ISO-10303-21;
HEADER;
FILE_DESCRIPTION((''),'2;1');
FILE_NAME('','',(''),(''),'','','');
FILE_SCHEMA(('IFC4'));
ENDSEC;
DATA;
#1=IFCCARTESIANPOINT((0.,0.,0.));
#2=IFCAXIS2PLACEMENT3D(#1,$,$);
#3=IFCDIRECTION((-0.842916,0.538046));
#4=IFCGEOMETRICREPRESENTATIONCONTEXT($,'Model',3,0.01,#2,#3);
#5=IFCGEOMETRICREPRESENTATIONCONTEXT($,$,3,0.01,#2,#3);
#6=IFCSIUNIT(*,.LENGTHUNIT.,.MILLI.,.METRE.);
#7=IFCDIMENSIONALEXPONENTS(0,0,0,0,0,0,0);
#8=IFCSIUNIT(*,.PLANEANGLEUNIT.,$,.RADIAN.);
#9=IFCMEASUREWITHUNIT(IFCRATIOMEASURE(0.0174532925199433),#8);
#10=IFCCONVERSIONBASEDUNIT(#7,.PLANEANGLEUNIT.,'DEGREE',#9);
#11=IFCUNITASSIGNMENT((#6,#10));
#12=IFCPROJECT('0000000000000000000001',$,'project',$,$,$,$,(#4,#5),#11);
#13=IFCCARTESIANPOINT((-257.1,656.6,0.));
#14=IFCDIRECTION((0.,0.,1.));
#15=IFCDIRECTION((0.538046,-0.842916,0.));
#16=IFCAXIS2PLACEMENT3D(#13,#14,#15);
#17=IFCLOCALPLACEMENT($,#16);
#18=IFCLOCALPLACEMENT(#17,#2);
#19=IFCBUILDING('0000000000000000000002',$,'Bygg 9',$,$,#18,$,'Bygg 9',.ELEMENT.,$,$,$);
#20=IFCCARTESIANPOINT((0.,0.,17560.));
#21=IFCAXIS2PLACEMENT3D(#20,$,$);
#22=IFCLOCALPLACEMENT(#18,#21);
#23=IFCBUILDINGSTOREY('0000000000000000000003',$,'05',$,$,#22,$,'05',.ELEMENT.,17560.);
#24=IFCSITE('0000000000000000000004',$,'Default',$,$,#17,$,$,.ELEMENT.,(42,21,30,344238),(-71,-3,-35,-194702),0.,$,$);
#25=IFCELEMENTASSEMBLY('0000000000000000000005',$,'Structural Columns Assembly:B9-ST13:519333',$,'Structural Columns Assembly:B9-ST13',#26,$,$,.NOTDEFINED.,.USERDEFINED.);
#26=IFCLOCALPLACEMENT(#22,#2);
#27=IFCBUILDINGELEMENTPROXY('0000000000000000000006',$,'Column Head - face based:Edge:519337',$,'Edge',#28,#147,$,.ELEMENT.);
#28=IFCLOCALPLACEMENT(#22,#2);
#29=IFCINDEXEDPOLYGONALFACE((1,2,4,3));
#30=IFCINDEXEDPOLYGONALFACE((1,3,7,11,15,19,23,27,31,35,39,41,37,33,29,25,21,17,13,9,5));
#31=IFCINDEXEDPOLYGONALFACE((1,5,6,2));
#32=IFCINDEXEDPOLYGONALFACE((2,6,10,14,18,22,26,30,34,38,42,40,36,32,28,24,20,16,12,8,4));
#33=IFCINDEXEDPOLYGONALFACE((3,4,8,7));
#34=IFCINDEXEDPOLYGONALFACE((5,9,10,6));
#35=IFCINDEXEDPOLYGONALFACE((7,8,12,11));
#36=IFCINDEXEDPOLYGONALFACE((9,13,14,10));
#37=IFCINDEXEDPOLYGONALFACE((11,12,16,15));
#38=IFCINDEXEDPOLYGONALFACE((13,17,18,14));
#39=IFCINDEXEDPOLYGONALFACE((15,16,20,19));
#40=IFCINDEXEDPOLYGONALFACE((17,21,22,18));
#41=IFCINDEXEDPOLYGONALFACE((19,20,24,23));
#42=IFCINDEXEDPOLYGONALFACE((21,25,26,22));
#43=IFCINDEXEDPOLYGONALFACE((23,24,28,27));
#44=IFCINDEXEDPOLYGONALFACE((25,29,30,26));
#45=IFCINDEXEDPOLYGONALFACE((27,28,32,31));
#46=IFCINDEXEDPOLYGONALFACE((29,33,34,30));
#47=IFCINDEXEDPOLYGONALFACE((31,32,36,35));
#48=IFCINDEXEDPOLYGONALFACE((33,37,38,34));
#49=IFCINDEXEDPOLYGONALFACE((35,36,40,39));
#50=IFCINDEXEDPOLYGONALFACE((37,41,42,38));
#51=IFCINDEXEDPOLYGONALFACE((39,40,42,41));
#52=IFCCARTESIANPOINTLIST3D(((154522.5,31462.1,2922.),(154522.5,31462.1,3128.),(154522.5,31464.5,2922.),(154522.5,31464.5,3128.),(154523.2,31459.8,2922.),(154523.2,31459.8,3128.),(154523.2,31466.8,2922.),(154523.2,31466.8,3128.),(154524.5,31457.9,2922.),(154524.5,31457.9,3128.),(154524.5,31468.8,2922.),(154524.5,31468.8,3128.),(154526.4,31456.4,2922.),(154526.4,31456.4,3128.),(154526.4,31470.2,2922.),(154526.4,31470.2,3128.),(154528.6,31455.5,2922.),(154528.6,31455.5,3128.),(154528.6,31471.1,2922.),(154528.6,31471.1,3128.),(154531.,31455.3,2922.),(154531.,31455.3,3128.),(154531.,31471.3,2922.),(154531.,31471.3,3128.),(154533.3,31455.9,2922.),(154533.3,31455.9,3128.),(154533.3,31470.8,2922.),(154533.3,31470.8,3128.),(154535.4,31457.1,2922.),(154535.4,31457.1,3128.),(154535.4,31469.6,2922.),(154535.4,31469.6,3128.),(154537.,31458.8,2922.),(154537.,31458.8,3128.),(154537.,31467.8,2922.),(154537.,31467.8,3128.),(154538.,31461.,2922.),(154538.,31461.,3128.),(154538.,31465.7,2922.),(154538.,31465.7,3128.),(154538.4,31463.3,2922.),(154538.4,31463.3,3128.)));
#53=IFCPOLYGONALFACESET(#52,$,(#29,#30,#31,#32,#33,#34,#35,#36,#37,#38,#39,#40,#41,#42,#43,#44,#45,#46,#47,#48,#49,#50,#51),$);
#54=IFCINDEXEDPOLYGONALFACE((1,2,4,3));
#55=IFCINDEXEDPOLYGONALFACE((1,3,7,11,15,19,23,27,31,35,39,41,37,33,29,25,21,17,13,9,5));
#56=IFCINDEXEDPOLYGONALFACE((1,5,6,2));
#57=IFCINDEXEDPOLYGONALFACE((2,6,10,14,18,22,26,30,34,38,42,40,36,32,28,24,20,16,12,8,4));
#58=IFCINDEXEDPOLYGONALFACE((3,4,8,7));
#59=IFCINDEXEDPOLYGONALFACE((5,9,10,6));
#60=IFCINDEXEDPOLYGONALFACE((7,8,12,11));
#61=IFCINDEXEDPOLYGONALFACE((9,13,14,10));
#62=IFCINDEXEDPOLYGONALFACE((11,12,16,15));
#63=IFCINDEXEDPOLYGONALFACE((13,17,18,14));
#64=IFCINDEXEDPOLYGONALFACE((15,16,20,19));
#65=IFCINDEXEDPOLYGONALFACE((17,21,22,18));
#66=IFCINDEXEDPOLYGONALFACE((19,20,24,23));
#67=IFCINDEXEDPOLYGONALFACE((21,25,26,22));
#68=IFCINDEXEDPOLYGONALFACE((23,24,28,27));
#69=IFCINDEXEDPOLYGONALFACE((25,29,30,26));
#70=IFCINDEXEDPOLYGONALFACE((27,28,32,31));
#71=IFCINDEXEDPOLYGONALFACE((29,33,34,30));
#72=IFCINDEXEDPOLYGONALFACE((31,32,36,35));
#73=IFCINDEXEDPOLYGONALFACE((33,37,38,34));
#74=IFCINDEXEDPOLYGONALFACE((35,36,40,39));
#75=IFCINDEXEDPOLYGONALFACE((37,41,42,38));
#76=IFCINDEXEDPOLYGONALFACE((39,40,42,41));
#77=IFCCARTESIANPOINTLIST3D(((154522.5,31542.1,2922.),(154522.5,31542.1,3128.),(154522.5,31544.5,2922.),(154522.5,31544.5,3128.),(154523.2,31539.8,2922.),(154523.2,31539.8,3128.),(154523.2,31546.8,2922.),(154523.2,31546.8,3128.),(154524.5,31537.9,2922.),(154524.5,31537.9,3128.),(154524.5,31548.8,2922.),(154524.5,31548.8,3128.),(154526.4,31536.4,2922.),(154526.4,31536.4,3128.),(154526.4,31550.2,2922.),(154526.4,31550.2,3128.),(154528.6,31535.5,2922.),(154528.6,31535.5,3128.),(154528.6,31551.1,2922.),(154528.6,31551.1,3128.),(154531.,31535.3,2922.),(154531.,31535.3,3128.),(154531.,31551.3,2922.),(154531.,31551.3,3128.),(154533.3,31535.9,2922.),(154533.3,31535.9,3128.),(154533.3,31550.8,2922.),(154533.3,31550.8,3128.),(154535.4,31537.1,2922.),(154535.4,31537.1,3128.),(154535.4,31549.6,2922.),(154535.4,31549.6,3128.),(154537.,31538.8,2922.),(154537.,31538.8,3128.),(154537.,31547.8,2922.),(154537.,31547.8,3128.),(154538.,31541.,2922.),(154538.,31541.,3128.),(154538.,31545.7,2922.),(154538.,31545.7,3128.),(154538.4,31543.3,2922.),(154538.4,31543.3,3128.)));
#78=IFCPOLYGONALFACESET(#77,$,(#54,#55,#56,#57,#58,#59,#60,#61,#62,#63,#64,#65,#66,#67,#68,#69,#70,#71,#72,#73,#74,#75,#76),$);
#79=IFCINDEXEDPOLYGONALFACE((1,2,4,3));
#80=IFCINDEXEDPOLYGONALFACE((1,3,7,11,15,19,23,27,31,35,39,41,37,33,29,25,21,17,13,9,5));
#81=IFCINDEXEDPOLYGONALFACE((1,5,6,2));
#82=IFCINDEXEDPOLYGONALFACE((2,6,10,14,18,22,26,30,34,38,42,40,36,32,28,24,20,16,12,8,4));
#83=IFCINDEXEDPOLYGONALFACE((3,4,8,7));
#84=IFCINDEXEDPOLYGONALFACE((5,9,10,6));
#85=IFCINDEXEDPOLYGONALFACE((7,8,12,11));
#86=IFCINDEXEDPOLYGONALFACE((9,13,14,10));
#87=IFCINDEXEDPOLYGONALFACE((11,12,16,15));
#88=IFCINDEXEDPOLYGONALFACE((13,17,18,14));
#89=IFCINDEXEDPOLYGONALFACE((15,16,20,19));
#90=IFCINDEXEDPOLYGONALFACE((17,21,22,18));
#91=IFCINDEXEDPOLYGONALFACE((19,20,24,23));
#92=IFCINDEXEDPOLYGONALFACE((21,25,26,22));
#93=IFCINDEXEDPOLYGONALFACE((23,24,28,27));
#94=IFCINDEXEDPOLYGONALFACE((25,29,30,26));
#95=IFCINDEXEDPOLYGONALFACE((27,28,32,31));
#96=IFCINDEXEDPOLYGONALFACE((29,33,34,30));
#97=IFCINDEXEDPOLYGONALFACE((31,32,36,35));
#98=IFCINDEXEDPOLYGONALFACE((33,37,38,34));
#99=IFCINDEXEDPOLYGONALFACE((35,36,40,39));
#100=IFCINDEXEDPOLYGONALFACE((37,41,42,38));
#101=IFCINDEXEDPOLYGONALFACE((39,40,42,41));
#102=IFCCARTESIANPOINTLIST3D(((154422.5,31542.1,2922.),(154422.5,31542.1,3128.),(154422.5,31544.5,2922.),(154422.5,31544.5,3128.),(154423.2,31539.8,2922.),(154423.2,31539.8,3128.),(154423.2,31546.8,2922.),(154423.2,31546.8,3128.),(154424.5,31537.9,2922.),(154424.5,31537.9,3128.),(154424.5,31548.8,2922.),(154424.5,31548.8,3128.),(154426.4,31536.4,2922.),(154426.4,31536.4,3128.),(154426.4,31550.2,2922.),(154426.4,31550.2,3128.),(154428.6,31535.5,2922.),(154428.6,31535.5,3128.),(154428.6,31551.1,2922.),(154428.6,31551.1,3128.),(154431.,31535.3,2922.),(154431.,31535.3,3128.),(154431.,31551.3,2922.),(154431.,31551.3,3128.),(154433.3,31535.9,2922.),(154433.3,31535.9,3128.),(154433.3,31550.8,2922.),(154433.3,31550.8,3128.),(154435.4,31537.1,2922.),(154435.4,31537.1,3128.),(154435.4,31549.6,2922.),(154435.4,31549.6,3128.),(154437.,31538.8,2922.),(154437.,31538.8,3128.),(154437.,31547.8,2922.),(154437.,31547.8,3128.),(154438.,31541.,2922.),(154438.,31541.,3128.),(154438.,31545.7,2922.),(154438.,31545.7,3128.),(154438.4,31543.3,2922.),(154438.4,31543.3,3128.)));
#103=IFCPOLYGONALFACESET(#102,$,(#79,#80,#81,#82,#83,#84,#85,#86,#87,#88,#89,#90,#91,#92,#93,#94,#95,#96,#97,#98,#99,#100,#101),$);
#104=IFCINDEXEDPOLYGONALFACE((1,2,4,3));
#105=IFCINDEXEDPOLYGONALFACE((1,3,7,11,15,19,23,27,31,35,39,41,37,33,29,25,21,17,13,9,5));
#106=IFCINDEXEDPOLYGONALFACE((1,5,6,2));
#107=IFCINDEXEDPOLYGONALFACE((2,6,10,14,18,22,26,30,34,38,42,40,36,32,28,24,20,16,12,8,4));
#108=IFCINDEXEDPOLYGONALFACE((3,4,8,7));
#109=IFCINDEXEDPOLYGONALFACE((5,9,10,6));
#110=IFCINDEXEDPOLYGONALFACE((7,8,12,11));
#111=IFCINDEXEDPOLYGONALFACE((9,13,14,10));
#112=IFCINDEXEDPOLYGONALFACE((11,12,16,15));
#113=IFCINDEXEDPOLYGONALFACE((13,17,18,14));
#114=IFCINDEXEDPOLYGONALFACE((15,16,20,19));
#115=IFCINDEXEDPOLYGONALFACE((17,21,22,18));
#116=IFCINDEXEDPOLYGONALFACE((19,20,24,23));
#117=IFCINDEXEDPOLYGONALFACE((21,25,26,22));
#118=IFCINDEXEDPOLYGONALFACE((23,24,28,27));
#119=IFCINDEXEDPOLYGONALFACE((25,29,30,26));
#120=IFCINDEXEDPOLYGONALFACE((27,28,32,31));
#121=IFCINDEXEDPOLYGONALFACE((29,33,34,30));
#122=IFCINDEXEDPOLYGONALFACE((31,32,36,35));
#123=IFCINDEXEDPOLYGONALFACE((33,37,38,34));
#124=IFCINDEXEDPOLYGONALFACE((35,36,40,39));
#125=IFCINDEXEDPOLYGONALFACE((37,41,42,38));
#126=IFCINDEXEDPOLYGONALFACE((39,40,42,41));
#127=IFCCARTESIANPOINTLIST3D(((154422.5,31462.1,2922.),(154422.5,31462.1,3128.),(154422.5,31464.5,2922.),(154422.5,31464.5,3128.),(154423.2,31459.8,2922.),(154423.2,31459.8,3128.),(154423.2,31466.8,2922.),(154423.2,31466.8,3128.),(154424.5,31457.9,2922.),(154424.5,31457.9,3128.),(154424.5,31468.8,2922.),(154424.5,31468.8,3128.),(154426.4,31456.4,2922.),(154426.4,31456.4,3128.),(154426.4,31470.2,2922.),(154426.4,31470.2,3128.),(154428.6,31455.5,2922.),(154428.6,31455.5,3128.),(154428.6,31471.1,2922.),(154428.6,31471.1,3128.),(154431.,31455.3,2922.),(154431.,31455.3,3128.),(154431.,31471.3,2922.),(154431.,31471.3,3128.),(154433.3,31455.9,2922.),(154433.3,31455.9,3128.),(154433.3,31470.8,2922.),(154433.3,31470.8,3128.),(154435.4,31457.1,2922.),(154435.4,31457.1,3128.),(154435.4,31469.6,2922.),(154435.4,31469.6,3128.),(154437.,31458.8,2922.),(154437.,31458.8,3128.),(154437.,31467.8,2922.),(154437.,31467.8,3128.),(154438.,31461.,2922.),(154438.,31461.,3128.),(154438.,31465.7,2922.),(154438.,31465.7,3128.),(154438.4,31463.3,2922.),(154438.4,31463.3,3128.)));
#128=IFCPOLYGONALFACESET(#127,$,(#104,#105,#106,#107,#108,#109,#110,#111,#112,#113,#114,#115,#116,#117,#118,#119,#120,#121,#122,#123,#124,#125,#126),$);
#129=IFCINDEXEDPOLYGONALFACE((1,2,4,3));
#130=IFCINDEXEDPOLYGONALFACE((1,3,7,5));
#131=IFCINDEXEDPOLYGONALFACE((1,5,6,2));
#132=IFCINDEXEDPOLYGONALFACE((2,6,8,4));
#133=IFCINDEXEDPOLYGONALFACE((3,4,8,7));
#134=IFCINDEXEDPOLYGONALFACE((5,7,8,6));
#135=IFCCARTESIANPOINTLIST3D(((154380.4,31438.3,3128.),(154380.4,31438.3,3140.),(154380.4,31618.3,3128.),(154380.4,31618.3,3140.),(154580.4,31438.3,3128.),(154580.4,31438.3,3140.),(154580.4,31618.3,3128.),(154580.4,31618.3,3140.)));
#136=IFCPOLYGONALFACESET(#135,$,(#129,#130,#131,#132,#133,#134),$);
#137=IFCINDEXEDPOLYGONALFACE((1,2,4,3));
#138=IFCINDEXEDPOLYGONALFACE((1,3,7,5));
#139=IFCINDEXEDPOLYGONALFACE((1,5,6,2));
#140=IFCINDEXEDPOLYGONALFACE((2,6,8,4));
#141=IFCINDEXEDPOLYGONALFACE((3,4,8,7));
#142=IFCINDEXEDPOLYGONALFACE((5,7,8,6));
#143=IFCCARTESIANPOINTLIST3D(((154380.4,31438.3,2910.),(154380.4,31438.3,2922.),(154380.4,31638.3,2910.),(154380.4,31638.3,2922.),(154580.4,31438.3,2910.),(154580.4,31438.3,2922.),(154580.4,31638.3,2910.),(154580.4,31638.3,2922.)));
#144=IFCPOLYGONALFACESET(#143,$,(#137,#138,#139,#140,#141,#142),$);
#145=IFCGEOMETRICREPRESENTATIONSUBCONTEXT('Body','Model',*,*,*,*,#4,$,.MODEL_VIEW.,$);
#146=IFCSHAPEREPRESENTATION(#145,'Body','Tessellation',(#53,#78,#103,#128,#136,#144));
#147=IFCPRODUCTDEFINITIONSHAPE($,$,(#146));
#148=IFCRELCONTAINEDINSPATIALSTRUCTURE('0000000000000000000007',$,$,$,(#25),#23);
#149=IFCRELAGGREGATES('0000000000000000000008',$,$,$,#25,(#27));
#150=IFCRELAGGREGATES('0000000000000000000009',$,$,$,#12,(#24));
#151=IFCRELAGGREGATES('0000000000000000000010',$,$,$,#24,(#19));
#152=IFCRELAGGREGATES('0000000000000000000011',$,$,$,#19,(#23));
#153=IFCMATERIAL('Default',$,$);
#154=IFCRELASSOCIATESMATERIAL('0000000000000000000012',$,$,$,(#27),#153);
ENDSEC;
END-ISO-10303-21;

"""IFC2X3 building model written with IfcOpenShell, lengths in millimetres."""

from ifc_helpers import new_model, entity, si_unit, converted_unit, direction, frame, frame_2d, origin, origin_2d_with_axis, place, context, subcontext, project, spatial, rectangle, circle, extrude, source, transform, mapped, material, element, aggregate, save


model = new_model("IFC2X3")

# Units and contexts
model_context = context("Model", 3, precision=0.01, world=origin(), true_north=direction((-0.842916, 0.538046)))
context_of_model = context(None, 3, precision=0.01, world=origin(), true_north=direction((-0.842916, 0.538046)))
body_context = subcontext(model_context, "Body", "Model", "MODEL_VIEW")
ifc_project = project(units=[si_unit("LENGTHUNIT", "METRE", prefix="MILLI"), converted_unit("PLANEANGLEUNIT", "DEGREE", entity("IfcRatioMeasure", 0.0174532925199433), si_unit("PLANEANGLEUNIT", "RADIAN"), dimensions=[0, 0, 0, 0, 0, 0, 0])], contexts=[model_context, context_of_model])

# Site, building, storey
site_placement = place(None, frame((-257.1, 656.6, 0.0), z_axis=(0.0, 0.0, 1.0), x_axis=(0.538046, -0.842916, 0.0)))
site = spatial("IfcSite", under=ifc_project, at=site_placement, Name="Default", CompositionType="ELEMENT", RefLatitude=(42, 21, 30, 344238), RefLongitude=(-71, -3, -35, -194702), RefElevation=0.0)
building_placement = place(site_placement, origin())
building = spatial("IfcBuilding", under=site, at=building_placement, Name="Bygg 9", LongName="Bygg 9", CompositionType="ELEMENT")
storey_placement = place(building_placement, frame((0.0, 0.0, 17560.0)))
storey = spatial("IfcBuildingStorey", under=building, at=storey_placement, Name="05", LongName="05", CompositionType="ELEMENT", Elevation=17560.0)

# Shared definitions
ifc_material_1 = material(Name="Default")

# Element assembly, building element proxy
assembly_1_placement = place(storey_placement, origin())
assembly_1 = element("IfcElementAssembly", 1, at=assembly_1_placement, inside=storey, Name="Structural Columns Assembly:B9-ST13:519333", ObjectType="Structural Columns Assembly:B9-ST13", AssemblyPlace="NOTDEFINED", PredefinedType="USERDEFINED")
shared_shape_1 = source(origin(), body_context, "Body", "SweptSolid", [
    extrude(circle(Radius=8.0, at=frame_2d((0.0, 0.0), x_axis=(1.0, 0.0))), frame((50.0, -135.0, 12.0)), (0.0, 0.0, 1.0), 206.0),
    extrude(circle(Radius=8.0, at=frame_2d((0.0, 0.0), x_axis=(1.0, 0.0))), frame((50.0, -55.0, 12.0)), (0.0, 0.0, 1.0), 206.0),
    extrude(circle(Radius=8.0, at=frame_2d((0.0, 0.0), x_axis=(1.0, 0.0))), frame((-50.0, -55.0, 12.0)), (0.0, 0.0, 1.0), 206.0),
    extrude(circle(Radius=8.0, at=frame_2d((0.0, 0.0), x_axis=(1.0, 0.0))), frame((-50.0, -135.0, 12.0)), (0.0, 0.0, 1.0), 206.0),
    extrude(rectangle(XDim=200.0, YDim=180.0, at=origin_2d_with_axis()), frame((0.0, -70.0, 218.0), z_axis=(0.0, 0.0, 1.0), x_axis=(-1.0, 0.0, 0.0)), (0.0, 0.0, 1.0), 12.0),
    extrude(rectangle(XDim=200.0, YDim=200.0, at=origin_2d_with_axis()), frame((0.0, -60.0, 0.0), z_axis=(0.0, 0.0, 1.0), x_axis=(0.0, 1.0, 0.0)), (0.0, 0.0, 1.0), 12.0),
])
proxy_1_placement = place(assembly_1_placement, frame((154480.4, 31598.3, 2910.0)))
proxy_1 = element("IfcBuildingElementProxy", 2, at=proxy_1_placement, material=ifc_material_1, Name="Column Head - face based:Edge:519337", ObjectType="Edge", CompositionType="ELEMENT", context=body_context, shape_type="MappedRepresentation", body=[
    mapped(shared_shape_1, transform((0.0, 0.0, 0.0), scale=1.0)),
])
aggregate(assembly_1, [proxy_1])

save(model, "model.ifc")
